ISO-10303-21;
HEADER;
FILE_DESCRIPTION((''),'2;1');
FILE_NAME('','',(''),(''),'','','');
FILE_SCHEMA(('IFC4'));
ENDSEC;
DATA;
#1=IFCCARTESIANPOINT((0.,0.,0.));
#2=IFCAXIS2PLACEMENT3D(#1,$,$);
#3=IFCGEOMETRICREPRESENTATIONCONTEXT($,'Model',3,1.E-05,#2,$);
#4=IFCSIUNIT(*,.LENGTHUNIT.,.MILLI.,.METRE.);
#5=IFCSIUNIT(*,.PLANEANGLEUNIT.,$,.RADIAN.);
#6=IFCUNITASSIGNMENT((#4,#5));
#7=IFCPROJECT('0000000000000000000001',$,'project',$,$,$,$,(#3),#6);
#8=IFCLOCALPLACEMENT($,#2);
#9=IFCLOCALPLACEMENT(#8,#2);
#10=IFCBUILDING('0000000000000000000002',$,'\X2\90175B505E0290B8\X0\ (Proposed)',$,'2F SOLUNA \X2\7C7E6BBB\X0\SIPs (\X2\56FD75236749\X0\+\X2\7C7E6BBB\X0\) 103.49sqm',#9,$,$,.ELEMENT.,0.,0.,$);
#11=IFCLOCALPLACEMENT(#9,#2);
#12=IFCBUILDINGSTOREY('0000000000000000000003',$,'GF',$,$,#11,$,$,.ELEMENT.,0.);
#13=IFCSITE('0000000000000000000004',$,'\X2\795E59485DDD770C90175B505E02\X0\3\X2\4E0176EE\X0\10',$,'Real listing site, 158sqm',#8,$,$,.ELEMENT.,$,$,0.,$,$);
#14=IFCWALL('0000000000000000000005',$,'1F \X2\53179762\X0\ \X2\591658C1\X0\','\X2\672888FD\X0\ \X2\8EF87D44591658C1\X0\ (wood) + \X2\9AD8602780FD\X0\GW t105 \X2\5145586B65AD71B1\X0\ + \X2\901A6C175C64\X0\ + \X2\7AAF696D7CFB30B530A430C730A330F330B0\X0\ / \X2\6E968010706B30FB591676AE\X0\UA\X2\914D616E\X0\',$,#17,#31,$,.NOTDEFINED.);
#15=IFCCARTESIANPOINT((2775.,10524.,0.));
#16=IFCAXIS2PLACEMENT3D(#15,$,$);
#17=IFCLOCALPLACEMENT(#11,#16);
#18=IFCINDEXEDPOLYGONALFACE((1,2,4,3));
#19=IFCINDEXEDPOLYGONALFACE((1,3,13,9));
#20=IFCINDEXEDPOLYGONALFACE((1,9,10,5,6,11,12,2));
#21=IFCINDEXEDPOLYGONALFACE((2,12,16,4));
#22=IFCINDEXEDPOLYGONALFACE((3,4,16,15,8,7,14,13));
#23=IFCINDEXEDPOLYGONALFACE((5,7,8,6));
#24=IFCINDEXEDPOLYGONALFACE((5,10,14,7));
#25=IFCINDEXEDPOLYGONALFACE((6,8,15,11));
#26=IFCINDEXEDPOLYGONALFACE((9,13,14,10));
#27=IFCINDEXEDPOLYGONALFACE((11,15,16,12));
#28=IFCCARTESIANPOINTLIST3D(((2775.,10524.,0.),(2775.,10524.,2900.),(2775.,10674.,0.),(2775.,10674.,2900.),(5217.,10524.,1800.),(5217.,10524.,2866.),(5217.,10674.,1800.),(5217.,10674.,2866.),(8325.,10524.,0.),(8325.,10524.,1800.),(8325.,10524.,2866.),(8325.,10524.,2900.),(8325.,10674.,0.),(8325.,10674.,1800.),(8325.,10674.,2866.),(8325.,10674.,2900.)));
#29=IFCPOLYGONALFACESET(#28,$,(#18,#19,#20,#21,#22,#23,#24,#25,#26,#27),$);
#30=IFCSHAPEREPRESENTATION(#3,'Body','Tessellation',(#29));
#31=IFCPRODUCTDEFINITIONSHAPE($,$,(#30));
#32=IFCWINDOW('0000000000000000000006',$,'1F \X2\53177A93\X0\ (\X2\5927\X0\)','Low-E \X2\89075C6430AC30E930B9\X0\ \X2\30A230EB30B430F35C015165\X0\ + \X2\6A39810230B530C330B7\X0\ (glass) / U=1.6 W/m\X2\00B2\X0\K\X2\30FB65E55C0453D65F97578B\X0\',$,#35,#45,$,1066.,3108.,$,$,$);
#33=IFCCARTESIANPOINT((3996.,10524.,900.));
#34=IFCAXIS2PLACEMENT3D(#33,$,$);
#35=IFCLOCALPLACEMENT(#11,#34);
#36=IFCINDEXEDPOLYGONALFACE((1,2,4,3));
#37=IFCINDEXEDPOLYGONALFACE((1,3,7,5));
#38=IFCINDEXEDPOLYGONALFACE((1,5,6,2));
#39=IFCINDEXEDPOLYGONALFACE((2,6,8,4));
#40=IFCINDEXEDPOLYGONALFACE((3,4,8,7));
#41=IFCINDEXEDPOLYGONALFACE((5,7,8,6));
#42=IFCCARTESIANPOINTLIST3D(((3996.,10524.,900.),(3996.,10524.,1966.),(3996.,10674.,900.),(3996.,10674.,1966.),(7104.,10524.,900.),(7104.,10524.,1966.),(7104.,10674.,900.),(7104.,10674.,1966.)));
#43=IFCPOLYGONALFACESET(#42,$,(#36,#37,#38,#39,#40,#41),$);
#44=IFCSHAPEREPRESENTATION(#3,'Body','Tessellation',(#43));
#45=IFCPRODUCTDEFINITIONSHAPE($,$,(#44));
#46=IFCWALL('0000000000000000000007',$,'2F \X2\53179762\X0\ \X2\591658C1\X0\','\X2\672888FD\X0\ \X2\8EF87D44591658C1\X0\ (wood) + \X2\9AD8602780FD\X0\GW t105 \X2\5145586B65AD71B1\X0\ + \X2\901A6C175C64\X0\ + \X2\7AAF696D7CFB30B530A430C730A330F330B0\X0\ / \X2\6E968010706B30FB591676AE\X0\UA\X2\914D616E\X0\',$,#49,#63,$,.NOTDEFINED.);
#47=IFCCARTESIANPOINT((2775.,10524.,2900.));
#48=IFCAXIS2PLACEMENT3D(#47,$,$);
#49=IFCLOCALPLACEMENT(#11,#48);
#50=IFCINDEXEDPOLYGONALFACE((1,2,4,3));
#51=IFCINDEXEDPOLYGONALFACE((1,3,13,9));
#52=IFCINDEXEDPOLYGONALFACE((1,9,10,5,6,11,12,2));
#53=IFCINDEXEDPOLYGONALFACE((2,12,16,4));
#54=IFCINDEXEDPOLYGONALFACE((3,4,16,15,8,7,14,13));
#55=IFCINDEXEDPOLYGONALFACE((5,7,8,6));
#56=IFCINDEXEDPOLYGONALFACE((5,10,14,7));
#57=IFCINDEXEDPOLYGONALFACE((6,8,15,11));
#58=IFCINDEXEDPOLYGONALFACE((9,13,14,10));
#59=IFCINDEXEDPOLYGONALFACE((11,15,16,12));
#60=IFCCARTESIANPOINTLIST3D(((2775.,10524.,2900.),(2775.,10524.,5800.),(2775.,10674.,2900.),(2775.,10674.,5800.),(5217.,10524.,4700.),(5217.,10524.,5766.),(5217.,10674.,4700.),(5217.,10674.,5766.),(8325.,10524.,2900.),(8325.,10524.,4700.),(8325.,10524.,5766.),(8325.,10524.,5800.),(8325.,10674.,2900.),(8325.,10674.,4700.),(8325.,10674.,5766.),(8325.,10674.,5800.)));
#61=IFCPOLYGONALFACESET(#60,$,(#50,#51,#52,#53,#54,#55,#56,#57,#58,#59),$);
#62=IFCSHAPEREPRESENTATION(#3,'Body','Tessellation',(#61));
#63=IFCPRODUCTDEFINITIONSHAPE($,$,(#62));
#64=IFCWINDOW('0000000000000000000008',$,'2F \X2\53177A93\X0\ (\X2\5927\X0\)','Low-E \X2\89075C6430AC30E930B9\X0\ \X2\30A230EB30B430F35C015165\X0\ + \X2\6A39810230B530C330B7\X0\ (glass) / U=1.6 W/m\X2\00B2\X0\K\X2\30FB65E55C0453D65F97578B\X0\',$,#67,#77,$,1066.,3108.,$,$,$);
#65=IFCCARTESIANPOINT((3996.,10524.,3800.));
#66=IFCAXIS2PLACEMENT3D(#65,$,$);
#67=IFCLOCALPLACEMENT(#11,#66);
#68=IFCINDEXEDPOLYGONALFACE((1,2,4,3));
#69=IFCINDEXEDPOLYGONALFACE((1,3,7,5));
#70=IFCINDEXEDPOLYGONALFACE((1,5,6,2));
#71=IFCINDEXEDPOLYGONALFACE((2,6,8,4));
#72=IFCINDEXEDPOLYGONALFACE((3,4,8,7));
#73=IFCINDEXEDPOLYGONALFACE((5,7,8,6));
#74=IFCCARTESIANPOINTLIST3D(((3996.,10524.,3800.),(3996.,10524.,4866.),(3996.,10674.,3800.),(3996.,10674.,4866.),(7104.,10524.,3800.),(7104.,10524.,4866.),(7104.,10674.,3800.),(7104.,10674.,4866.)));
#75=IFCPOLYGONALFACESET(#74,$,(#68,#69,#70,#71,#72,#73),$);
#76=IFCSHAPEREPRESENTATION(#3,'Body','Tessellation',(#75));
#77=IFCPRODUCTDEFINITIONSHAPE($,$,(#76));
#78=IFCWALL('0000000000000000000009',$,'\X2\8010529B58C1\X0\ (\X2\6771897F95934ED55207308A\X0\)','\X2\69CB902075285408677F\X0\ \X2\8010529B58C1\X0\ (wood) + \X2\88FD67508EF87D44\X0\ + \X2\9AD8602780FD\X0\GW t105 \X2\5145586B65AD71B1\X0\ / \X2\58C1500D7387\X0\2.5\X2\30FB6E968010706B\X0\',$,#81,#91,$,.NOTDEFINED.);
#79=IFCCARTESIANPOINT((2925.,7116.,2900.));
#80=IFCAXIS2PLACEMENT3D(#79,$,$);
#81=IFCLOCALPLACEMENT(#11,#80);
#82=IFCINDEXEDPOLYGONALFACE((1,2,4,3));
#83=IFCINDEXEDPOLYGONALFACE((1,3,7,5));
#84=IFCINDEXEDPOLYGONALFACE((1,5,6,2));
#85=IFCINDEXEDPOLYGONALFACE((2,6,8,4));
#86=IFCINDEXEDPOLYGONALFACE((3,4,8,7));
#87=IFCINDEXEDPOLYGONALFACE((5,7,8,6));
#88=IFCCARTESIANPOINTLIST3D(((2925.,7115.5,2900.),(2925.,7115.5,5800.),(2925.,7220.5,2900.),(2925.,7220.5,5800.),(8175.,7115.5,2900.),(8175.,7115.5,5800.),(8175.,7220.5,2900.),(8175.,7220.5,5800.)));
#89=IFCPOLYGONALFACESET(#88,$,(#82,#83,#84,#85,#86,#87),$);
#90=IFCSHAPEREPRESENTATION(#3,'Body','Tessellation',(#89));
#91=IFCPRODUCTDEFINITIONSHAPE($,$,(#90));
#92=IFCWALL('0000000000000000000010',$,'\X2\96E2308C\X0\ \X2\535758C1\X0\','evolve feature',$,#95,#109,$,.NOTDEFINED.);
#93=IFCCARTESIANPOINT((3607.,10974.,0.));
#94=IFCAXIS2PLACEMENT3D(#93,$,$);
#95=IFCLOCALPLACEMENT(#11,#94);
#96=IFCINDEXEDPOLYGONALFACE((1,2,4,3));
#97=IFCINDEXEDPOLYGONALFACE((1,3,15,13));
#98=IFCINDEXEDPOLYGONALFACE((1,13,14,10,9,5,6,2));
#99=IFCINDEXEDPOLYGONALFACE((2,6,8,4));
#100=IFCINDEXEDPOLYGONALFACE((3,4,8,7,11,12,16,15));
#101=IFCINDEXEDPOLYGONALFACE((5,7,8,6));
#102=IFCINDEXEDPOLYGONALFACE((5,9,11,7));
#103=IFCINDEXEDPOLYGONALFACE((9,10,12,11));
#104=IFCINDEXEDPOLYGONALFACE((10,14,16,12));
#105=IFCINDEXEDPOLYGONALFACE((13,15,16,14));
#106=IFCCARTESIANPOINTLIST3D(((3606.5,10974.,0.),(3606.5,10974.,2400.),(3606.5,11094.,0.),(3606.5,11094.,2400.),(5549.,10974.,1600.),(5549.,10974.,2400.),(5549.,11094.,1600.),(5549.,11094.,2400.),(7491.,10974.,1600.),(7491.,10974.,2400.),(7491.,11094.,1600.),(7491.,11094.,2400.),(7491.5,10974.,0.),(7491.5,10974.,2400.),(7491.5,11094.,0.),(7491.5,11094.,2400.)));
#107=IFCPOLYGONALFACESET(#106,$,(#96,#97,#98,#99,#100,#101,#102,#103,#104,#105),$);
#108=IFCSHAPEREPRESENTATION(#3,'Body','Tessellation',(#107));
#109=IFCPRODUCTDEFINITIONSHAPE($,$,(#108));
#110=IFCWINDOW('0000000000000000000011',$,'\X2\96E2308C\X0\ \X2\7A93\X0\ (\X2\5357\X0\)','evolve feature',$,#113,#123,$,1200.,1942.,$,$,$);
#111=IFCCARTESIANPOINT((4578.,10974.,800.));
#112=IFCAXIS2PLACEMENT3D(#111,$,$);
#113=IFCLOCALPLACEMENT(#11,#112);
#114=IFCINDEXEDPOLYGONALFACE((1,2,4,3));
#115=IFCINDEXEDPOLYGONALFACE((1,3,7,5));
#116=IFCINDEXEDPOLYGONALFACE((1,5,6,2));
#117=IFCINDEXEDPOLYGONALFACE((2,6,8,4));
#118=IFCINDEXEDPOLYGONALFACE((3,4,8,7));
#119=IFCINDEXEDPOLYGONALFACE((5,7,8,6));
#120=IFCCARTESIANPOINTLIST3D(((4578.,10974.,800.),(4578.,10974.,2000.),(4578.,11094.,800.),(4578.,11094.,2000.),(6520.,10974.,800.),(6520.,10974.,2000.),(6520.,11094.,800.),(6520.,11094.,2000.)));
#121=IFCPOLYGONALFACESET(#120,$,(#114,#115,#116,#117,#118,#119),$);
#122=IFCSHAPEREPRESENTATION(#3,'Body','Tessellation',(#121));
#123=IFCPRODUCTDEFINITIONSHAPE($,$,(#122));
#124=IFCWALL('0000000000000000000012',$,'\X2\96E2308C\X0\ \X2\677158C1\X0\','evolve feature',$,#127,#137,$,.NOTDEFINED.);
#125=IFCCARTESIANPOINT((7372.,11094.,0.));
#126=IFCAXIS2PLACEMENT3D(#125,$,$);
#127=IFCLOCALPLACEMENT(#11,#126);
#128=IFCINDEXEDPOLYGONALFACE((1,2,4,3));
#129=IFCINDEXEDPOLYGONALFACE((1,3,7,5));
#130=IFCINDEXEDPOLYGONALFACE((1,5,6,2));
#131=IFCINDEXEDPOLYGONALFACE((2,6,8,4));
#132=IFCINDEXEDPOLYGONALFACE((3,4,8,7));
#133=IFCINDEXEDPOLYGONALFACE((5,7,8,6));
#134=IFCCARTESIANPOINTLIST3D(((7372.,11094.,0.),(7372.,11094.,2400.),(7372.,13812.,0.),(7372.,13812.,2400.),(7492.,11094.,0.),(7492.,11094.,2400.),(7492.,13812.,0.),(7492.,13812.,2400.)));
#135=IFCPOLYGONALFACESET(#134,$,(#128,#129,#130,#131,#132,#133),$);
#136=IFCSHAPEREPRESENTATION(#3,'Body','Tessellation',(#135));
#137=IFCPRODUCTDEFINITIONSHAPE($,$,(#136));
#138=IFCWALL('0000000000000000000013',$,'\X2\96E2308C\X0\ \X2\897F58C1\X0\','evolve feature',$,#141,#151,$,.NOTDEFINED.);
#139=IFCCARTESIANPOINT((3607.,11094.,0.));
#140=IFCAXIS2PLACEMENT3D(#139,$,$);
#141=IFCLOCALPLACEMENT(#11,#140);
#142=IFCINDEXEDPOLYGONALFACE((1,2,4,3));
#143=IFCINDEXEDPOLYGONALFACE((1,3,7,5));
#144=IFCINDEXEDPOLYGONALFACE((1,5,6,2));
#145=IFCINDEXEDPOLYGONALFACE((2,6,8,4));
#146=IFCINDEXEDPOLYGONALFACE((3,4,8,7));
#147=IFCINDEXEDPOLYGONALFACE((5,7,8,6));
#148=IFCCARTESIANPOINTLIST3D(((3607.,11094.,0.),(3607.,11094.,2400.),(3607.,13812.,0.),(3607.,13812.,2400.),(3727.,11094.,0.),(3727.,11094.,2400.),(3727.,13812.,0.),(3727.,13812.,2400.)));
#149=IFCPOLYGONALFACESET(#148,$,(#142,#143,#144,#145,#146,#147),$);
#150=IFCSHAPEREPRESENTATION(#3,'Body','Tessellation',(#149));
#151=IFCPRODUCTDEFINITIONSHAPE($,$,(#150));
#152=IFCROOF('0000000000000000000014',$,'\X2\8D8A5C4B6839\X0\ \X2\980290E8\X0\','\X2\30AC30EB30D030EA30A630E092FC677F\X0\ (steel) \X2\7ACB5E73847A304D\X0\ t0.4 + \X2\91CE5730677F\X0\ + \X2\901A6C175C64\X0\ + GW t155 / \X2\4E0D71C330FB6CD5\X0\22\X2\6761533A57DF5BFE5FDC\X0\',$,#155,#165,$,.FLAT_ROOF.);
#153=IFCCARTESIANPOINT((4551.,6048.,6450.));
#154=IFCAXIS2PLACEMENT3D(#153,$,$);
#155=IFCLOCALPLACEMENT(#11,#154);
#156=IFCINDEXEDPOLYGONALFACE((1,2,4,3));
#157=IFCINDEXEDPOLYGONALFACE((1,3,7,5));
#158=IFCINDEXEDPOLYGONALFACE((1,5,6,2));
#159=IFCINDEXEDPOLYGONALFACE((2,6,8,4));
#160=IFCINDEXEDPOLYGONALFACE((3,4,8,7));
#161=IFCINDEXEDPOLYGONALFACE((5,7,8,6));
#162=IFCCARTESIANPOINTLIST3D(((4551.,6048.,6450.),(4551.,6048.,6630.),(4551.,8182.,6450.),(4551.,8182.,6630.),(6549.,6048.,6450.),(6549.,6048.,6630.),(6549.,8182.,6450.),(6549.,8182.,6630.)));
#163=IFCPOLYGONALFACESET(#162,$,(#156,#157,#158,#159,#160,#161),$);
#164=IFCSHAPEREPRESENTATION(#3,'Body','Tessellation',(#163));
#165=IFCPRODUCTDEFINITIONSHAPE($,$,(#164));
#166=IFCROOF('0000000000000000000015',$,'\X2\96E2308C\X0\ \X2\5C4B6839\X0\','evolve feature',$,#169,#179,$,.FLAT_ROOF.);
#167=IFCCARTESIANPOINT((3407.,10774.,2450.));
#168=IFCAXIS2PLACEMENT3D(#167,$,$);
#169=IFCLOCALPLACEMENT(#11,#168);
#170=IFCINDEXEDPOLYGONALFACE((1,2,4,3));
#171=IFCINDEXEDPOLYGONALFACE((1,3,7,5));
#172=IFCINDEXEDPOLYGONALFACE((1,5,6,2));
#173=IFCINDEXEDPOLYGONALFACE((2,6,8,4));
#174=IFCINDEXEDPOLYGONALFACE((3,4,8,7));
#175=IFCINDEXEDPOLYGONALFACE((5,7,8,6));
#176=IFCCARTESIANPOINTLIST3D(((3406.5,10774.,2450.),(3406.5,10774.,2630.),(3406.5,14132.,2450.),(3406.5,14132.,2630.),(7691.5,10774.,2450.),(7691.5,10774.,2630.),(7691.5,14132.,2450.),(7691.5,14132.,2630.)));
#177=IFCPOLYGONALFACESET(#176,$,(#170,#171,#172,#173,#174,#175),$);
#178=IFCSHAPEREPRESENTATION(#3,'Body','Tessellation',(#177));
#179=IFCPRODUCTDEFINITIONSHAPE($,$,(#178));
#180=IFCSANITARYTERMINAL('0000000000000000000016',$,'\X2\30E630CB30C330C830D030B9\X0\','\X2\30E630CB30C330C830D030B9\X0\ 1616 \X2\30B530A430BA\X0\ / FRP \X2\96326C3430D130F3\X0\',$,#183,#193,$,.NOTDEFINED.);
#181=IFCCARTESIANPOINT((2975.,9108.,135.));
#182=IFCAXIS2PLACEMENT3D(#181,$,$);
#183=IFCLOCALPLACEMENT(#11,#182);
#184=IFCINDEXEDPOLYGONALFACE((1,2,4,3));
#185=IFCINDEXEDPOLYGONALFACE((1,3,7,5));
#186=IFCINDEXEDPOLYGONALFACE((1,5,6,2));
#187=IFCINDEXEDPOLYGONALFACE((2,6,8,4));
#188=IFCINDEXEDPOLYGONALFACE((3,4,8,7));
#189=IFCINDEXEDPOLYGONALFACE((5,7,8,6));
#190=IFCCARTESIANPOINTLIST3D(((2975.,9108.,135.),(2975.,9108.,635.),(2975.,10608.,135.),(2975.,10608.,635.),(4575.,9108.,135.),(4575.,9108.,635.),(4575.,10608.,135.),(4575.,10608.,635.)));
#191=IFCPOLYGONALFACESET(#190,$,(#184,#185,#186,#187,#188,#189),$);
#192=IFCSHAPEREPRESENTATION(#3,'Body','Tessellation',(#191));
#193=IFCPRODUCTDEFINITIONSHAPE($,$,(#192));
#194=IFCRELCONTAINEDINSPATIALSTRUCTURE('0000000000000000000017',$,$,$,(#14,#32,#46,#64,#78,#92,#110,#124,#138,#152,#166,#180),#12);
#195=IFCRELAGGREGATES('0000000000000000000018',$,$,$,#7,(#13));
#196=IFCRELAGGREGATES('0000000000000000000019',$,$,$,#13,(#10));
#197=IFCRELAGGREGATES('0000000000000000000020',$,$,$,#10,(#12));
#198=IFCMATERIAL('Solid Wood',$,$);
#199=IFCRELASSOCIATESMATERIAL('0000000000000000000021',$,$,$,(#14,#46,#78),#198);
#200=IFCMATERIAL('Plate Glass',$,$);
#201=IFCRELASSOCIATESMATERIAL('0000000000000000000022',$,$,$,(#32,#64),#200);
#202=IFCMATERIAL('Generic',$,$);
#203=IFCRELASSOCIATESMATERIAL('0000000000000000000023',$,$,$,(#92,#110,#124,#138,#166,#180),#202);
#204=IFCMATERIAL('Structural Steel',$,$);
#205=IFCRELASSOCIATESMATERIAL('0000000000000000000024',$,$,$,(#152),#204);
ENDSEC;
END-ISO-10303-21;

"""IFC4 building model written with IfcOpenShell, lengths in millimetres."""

from ifc_helpers import new_model, si_unit, frame, frame_2d, origin, place, context, project, spatial, rectangle, extrude, material, element, fill, save


model = new_model("IFC4")

# Units and contexts
model_context = context("Model", 3, precision=1e-05, world=origin())
ifc_project = project(units=[si_unit("LENGTHUNIT", "METRE", prefix="MILLI"), si_unit("PLANEANGLEUNIT", "RADIAN")], contexts=[model_context])

# Site, building, storey
site_placement = place(None, origin())
site = spatial("IfcSite", under=ifc_project, at=site_placement, Name="神奈川県逗子市3丁目10", ObjectType="Real listing site, 158sqm", CompositionType="ELEMENT", RefElevation=0.0)
building_placement = place(site_placement, origin())
building = spatial("IfcBuilding", under=site, at=building_placement, Name="逗子市邸 (Proposed)", ObjectType="2F SOLUNA 籾殻SIPs (国産杉+籾殻) 103.49sqm", CompositionType="ELEMENT", ElevationOfRefHeight=0.0, ElevationOfTerrain=0.0)
storey_placement = place(building_placement, origin())
storey = spatial("IfcBuildingStorey", under=building, at=storey_placement, Name="GF", CompositionType="ELEMENT", Elevation=0.0)

# Shared definitions
ifc_material_1 = material(Name="Generic")

# Wall, opening, window
ifc_material_2 = material(Name="Solid Wood")
wall_1_placement = place(storey_placement, frame((2775.0, 10524.0, 0.0)))
wall_1 = element("IfcWall", 1, at=wall_1_placement, inside=storey, material=ifc_material_2, Name="1F 北面 外壁", Description="木製 軸組外壁 (wood) + 高性能GW t105 充填断熱 + 通気層 + 窯業系サイディング / 準耐火・外皮UA配慮", PredefinedType="NOTDEFINED", context=model_context, shape_type="SweptSolid", body=[
    extrude(rectangle(XDim=5550.0, YDim=150.0, at=frame_2d((2775.0, 75.0))), frame((2775.0, 10524.0, 0.0)), (0.0, 0.0, 1.0), 2900.0),
])
opening_1_placement = place(storey_placement, frame((3996.0, 10524.0, 900.0)))
opening_1 = element("IfcOpeningElement", 2, at=opening_1_placement, cuts=wall_1, PredefinedType="NOTDEFINED", context=model_context, shape_type="SweptSolid", body=[
    extrude(rectangle(XDim=3108.0, YDim=150.0, at=frame_2d((1554.0, 75.0))), frame((3996.0, 10524.0, 900.0)), (0.0, 0.0, 1.0), 1066.0),
])
ifc_material_3 = material(Name="Plate Glass")
window_1_placement = place(storey_placement, frame((3996.0, 10524.0, 900.0)))
window_1 = element("IfcWindow", 3, at=window_1_placement, inside=storey, material=ifc_material_3, Name="1F 北窓 (大)", Description="Low-E 複層ガラス アルゴン封入 + 樹脂サッシ (glass) / U=1.6 W/m²K・日射取得型", OverallHeight=1066.0, OverallWidth=3108.0, context=model_context, shape_type="SweptSolid", body=[
    extrude(rectangle(XDim=3108.0, YDim=150.0, at=frame_2d((1554.0, 75.0))), frame((3996.0, 10524.0, 900.0)), (0.0, 0.0, 1.0), 1066.0),
])
fill(opening_1, window_1)

# Wall, opening, window
wall_2_placement = place(storey_placement, frame((2775.0, 10524.0, 2900.0)))
wall_2 = element("IfcWall", 4, at=wall_2_placement, inside=storey, material=ifc_material_2, Name="2F 北面 外壁", Description="木製 軸組外壁 (wood) + 高性能GW t105 充填断熱 + 通気層 + 窯業系サイディング / 準耐火・外皮UA配慮", PredefinedType="NOTDEFINED", context=model_context, shape_type="SweptSolid", body=[
    extrude(rectangle(XDim=5550.0, YDim=150.0, at=frame_2d((2775.0, 75.0))), frame((2775.0, 10524.0, 2900.0)), (0.0, 0.0, 1.0), 2900.0),
])
opening_2_placement = place(storey_placement, frame((3996.0, 10524.0, 3800.0)))
opening_2 = element("IfcOpeningElement", 5, at=opening_2_placement, cuts=wall_2, PredefinedType="NOTDEFINED", context=model_context, shape_type="SweptSolid", body=[
    extrude(rectangle(XDim=3108.0, YDim=150.0, at=frame_2d((1554.0, 75.0))), frame((3996.0, 10524.0, 3800.0)), (0.0, 0.0, 1.0), 1066.0),
])
window_2_placement = place(storey_placement, frame((3996.0, 10524.0, 3800.0)))
window_2 = element("IfcWindow", 6, at=window_2_placement, inside=storey, material=ifc_material_3, Name="2F 北窓 (大)", Description="Low-E 複層ガラス アルゴン封入 + 樹脂サッシ (glass) / U=1.6 W/m²K・日射取得型", OverallHeight=1066.0, OverallWidth=3108.0, context=model_context, shape_type="SweptSolid", body=[
    extrude(rectangle(XDim=3108.0, YDim=150.0, at=frame_2d((1554.0, 75.0))), frame((3996.0, 10524.0, 3800.0)), (0.0, 0.0, 1.0), 1066.0),
])
fill(opening_2, window_2)

# Wall
wall_3_placement = place(storey_placement, frame((2925.0, 7116.0, 2900.0)))
element("IfcWall", 7, at=wall_3_placement, inside=storey, material=ifc_material_2, Name="耐力壁 (東西間仕切り)", Description="構造用合板 耐力壁 (wood) + 製材軸組 + 高性能GW t105 充填断熱 / 壁倍率2.5・準耐火", PredefinedType="NOTDEFINED", context=model_context, shape_type="SweptSolid", body=[
    extrude(rectangle(XDim=5250.0, YDim=105.0, at=frame_2d((2625.0, 52.0))), frame((2925.0, 7116.0, 2900.0)), (0.0, 0.0, 1.0), 2900.0),
])

# Wall, opening, window
wall_4_placement = place(storey_placement, frame((3607.0, 10974.0, 0.0)))
wall_4 = element("IfcWall", 8, at=wall_4_placement, inside=storey, material=ifc_material_1, Name="離れ 南壁", Description="evolve feature", PredefinedType="NOTDEFINED", context=model_context, shape_type="SweptSolid", body=[
    extrude(rectangle(XDim=3885.0, YDim=120.0, at=frame_2d((1942.0, 60.0))), frame((3607.0, 10974.0, 0.0)), (0.0, 0.0, 1.0), 2400.0),
])
opening_3_placement = place(storey_placement, frame((4578.0, 10974.0, 800.0)))
opening_3 = element("IfcOpeningElement", 9, at=opening_3_placement, cuts=wall_4, PredefinedType="NOTDEFINED", context=model_context, shape_type="SweptSolid", body=[
    extrude(rectangle(XDim=1942.0, YDim=120.0, at=frame_2d((971.0, 60.0))), frame((4578.0, 10974.0, 800.0)), (0.0, 0.0, 1.0), 1200.0),
])
window_3_placement = place(storey_placement, frame((4578.0, 10974.0, 800.0)))
window_3 = element("IfcWindow", 10, at=window_3_placement, inside=storey, material=ifc_material_1, Name="離れ 窓 (南)", Description="evolve feature", OverallHeight=1200.0, OverallWidth=1942.0, context=model_context, shape_type="SweptSolid", body=[
    extrude(rectangle(XDim=1942.0, YDim=120.0, at=frame_2d((971.0, 60.0))), frame((4578.0, 10974.0, 800.0)), (0.0, 0.0, 1.0), 1200.0),
])
fill(opening_3, window_3)

# Walls
wall_5_placement = place(storey_placement, frame((7372.0, 11094.0, 0.0)))
element("IfcWall", 11, at=wall_5_placement, inside=storey, material=ifc_material_1, Name="離れ 東壁", Description="evolve feature", PredefinedType="NOTDEFINED", context=model_context, shape_type="SweptSolid", body=[
    extrude(rectangle(XDim=120.0, YDim=2718.0, at=frame_2d((60.0, 1359.0))), frame((7372.0, 11094.0, 0.0)), (0.0, 0.0, 1.0), 2400.0),
])
wall_6_placement = place(storey_placement, frame((3607.0, 11094.0, 0.0)))
element("IfcWall", 12, at=wall_6_placement, inside=storey, material=ifc_material_1, Name="離れ 西壁", Description="evolve feature", PredefinedType="NOTDEFINED", context=model_context, shape_type="SweptSolid", body=[
    extrude(rectangle(XDim=120.0, YDim=2718.0, at=frame_2d((60.0, 1359.0))), frame((3607.0, 11094.0, 0.0)), (0.0, 0.0, 1.0), 2400.0),
])

# Roofs
ifc_material_4 = material(Name="Structural Steel")
roof_1_placement = place(storey_placement, frame((4551.0, 6048.0, 6450.0)))
element("IfcRoof", 13, at=roof_1_placement, inside=storey, material=ifc_material_4, Name="越屋根 頂部", Description="ガルバリウム鋼板 (steel) 立平葺き t0.4 + 野地板 + 通気層 + GW t155 / 不燃・法22条区域対応", PredefinedType="FLAT_ROOF", context=model_context, shape_type="SweptSolid", body=[
    extrude(rectangle(XDim=1998.0, YDim=2134.0, at=frame_2d((999.0, 1067.0))), frame((4551.0, 6048.0, 6450.0)), (0.0, 0.0, 1.0), 180.0),
])
roof_2_placement = place(storey_placement, frame((3407.0, 10774.0, 2450.0)))
element("IfcRoof", 14, at=roof_2_placement, inside=storey, material=ifc_material_1, Name="離れ 屋根", Description="evolve feature", PredefinedType="FLAT_ROOF", context=model_context, shape_type="SweptSolid", body=[
    extrude(rectangle(XDim=4285.0, YDim=3358.0, at=frame_2d((2142.0, 1679.0))), frame((3407.0, 10774.0, 2450.0)), (0.0, 0.0, 1.0), 180.0),
])

# Sanitary terminal
sanitary_terminal_1_placement = place(storey_placement, frame((2975.0, 9108.0, 135.0)))
element("IfcSanitaryTerminal", 15, at=sanitary_terminal_1_placement, inside=storey, material=ifc_material_1, Name="ユニットバス", Description="ユニットバス 1616 サイズ / FRP 防水パン", PredefinedType="NOTDEFINED", context=model_context, shape_type="SweptSolid", body=[
    extrude(rectangle(XDim=1600.0, YDim=1500.0, at=frame_2d((800.0, 750.0))), frame((2975.0, 9108.0, 135.0)), (0.0, 0.0, 1.0), 500.0),
])

save(model, "model.ifc")
